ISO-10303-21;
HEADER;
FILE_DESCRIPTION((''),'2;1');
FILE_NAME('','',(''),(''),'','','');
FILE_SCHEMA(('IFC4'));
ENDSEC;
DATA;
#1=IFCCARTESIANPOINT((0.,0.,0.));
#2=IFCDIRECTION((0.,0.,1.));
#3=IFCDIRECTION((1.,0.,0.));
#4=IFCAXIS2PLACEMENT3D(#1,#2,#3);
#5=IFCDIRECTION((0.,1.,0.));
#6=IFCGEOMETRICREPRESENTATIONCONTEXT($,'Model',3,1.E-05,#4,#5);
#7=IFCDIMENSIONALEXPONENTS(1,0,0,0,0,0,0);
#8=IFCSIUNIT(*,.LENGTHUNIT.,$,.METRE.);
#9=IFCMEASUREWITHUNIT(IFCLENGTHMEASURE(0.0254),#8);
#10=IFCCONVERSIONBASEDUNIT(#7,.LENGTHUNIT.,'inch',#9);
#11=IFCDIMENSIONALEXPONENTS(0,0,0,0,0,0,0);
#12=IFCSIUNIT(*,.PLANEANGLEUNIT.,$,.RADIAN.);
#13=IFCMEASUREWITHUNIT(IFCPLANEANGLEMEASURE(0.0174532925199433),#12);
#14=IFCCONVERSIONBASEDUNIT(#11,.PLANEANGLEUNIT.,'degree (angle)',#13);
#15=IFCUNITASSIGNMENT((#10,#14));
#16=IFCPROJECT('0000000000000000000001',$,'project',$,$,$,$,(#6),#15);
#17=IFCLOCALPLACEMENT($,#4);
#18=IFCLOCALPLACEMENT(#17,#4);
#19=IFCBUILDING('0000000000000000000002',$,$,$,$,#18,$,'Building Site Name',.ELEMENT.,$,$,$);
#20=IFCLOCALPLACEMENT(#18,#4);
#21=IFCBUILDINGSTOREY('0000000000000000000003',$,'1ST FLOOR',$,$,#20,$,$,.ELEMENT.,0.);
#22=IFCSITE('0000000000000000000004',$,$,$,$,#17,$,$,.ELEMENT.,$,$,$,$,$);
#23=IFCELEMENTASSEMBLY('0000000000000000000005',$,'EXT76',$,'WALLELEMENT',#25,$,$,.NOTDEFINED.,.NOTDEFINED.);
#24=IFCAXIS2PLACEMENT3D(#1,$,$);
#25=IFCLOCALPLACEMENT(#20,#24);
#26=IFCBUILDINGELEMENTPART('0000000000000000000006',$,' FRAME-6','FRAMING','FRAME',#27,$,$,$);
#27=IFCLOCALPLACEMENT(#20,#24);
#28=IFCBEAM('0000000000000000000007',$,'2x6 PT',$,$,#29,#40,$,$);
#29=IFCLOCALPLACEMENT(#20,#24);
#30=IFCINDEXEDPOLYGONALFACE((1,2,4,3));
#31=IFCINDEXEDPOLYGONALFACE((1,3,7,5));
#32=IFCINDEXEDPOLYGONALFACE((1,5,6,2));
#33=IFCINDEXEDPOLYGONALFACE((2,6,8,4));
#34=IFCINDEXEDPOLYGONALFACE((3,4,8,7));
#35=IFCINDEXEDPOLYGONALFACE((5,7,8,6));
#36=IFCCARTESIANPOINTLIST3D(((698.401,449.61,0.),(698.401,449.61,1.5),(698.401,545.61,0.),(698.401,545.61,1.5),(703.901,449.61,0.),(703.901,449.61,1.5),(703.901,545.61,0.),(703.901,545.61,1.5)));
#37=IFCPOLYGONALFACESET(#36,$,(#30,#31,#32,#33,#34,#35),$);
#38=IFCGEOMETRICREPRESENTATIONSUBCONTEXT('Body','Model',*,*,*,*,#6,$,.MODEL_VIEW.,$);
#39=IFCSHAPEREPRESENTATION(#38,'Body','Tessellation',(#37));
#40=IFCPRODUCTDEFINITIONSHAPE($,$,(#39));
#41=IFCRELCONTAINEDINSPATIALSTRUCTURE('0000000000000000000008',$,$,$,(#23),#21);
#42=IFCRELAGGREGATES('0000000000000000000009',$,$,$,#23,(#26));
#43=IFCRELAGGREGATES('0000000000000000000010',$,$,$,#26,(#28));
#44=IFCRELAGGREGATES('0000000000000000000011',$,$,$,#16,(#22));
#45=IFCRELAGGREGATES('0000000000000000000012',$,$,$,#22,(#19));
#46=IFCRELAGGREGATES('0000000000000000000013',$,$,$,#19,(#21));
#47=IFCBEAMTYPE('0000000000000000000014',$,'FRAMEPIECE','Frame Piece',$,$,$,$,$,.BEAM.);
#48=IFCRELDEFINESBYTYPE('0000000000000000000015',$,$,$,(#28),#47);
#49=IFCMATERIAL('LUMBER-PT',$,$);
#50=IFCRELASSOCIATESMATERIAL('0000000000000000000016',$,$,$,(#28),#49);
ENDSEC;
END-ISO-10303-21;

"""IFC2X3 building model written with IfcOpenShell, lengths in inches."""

from ifc_helpers import new_model, entity, si_unit, converted_unit, direction, frame, frame_2d, origin_with_axes, place, context, subcontext, project, spatial, rectangle, extrude, material, type_object, element, aggregate, save


model = new_model("IFC2X3")

# Units and contexts
model_context = context("Model", 3, precision=1e-05, world=origin_with_axes(), true_north=direction((0.0, 1.0, 0.0)))
body_context = subcontext(model_context, "Body", "Model", "MODEL_VIEW")
ifc_project = project(units=[converted_unit("LENGTHUNIT", "inch", entity("IfcLengthMeasure", 0.0254), si_unit("LENGTHUNIT", "METRE"), dimensions=[1, 0, 0, 0, 0, 0, 0]), converted_unit("PLANEANGLEUNIT", "degree (angle)", entity("IfcPlaneAngleMeasure", 0.0174532925199433), si_unit("PLANEANGLEUNIT", "RADIAN"), dimensions=[0, 0, 0, 0, 0, 0, 0])], contexts=[model_context])

# Site, building, storey
site_placement = place(None, origin_with_axes())
site = spatial("IfcSite", under=ifc_project, at=site_placement, CompositionType="ELEMENT")
building_placement = place(site_placement, origin_with_axes())
building = spatial("IfcBuilding", under=site, at=building_placement, LongName="Building Site Name", CompositionType="ELEMENT")
storey_placement = place(building_placement, origin_with_axes())
storey = spatial("IfcBuildingStorey", under=building, at=storey_placement, Name="1ST FLOOR", CompositionType="ELEMENT", Elevation=0.0)

# Shared definitions
beam_type = type_object("IfcBeamType", Name="FRAMEPIECE", Description="Frame Piece", PredefinedType="BEAM")

# Element assembly, building element part
assembly_1_placement = place(storey_placement, origin_with_axes())
assembly_1 = element("IfcElementAssembly", 1, at=assembly_1_placement, inside=storey, Name="EXT76", ObjectType="WALLELEMENT", AssemblyPlace="NOTDEFINED", PredefinedType="NOTDEFINED")
building_element_part_1 = element("IfcBuildingElementPart", 2, Name=" FRAME-6", Description="FRAMING", ObjectType="FRAME")
aggregate(assembly_1, [building_element_part_1])

# Beam
ifc_material_1 = material(Name="LUMBER-PT")
beam_1_placement = place(assembly_1_placement, frame((701.151, 545.61, 0.75), z_axis=(0.0, -1.0, 0.0), x_axis=(0.0, 0.0, 1.0)))
beam_1 = element("IfcBeam", 3, at=beam_1_placement, type_object=beam_type, material=ifc_material_1, Name="2x6 PT", context=body_context, shape_type="SweptSolid", body=[
    extrude(rectangle(XDim=1.5, YDim=5.5, at=frame_2d((0.0, 0.0), x_axis=(-1.0, 0.0))), origin_with_axes(), (0.0, 0.0, 1.0), 96.0),
])
aggregate(building_element_part_1, [beam_1])

save(model, "model.ifc")
